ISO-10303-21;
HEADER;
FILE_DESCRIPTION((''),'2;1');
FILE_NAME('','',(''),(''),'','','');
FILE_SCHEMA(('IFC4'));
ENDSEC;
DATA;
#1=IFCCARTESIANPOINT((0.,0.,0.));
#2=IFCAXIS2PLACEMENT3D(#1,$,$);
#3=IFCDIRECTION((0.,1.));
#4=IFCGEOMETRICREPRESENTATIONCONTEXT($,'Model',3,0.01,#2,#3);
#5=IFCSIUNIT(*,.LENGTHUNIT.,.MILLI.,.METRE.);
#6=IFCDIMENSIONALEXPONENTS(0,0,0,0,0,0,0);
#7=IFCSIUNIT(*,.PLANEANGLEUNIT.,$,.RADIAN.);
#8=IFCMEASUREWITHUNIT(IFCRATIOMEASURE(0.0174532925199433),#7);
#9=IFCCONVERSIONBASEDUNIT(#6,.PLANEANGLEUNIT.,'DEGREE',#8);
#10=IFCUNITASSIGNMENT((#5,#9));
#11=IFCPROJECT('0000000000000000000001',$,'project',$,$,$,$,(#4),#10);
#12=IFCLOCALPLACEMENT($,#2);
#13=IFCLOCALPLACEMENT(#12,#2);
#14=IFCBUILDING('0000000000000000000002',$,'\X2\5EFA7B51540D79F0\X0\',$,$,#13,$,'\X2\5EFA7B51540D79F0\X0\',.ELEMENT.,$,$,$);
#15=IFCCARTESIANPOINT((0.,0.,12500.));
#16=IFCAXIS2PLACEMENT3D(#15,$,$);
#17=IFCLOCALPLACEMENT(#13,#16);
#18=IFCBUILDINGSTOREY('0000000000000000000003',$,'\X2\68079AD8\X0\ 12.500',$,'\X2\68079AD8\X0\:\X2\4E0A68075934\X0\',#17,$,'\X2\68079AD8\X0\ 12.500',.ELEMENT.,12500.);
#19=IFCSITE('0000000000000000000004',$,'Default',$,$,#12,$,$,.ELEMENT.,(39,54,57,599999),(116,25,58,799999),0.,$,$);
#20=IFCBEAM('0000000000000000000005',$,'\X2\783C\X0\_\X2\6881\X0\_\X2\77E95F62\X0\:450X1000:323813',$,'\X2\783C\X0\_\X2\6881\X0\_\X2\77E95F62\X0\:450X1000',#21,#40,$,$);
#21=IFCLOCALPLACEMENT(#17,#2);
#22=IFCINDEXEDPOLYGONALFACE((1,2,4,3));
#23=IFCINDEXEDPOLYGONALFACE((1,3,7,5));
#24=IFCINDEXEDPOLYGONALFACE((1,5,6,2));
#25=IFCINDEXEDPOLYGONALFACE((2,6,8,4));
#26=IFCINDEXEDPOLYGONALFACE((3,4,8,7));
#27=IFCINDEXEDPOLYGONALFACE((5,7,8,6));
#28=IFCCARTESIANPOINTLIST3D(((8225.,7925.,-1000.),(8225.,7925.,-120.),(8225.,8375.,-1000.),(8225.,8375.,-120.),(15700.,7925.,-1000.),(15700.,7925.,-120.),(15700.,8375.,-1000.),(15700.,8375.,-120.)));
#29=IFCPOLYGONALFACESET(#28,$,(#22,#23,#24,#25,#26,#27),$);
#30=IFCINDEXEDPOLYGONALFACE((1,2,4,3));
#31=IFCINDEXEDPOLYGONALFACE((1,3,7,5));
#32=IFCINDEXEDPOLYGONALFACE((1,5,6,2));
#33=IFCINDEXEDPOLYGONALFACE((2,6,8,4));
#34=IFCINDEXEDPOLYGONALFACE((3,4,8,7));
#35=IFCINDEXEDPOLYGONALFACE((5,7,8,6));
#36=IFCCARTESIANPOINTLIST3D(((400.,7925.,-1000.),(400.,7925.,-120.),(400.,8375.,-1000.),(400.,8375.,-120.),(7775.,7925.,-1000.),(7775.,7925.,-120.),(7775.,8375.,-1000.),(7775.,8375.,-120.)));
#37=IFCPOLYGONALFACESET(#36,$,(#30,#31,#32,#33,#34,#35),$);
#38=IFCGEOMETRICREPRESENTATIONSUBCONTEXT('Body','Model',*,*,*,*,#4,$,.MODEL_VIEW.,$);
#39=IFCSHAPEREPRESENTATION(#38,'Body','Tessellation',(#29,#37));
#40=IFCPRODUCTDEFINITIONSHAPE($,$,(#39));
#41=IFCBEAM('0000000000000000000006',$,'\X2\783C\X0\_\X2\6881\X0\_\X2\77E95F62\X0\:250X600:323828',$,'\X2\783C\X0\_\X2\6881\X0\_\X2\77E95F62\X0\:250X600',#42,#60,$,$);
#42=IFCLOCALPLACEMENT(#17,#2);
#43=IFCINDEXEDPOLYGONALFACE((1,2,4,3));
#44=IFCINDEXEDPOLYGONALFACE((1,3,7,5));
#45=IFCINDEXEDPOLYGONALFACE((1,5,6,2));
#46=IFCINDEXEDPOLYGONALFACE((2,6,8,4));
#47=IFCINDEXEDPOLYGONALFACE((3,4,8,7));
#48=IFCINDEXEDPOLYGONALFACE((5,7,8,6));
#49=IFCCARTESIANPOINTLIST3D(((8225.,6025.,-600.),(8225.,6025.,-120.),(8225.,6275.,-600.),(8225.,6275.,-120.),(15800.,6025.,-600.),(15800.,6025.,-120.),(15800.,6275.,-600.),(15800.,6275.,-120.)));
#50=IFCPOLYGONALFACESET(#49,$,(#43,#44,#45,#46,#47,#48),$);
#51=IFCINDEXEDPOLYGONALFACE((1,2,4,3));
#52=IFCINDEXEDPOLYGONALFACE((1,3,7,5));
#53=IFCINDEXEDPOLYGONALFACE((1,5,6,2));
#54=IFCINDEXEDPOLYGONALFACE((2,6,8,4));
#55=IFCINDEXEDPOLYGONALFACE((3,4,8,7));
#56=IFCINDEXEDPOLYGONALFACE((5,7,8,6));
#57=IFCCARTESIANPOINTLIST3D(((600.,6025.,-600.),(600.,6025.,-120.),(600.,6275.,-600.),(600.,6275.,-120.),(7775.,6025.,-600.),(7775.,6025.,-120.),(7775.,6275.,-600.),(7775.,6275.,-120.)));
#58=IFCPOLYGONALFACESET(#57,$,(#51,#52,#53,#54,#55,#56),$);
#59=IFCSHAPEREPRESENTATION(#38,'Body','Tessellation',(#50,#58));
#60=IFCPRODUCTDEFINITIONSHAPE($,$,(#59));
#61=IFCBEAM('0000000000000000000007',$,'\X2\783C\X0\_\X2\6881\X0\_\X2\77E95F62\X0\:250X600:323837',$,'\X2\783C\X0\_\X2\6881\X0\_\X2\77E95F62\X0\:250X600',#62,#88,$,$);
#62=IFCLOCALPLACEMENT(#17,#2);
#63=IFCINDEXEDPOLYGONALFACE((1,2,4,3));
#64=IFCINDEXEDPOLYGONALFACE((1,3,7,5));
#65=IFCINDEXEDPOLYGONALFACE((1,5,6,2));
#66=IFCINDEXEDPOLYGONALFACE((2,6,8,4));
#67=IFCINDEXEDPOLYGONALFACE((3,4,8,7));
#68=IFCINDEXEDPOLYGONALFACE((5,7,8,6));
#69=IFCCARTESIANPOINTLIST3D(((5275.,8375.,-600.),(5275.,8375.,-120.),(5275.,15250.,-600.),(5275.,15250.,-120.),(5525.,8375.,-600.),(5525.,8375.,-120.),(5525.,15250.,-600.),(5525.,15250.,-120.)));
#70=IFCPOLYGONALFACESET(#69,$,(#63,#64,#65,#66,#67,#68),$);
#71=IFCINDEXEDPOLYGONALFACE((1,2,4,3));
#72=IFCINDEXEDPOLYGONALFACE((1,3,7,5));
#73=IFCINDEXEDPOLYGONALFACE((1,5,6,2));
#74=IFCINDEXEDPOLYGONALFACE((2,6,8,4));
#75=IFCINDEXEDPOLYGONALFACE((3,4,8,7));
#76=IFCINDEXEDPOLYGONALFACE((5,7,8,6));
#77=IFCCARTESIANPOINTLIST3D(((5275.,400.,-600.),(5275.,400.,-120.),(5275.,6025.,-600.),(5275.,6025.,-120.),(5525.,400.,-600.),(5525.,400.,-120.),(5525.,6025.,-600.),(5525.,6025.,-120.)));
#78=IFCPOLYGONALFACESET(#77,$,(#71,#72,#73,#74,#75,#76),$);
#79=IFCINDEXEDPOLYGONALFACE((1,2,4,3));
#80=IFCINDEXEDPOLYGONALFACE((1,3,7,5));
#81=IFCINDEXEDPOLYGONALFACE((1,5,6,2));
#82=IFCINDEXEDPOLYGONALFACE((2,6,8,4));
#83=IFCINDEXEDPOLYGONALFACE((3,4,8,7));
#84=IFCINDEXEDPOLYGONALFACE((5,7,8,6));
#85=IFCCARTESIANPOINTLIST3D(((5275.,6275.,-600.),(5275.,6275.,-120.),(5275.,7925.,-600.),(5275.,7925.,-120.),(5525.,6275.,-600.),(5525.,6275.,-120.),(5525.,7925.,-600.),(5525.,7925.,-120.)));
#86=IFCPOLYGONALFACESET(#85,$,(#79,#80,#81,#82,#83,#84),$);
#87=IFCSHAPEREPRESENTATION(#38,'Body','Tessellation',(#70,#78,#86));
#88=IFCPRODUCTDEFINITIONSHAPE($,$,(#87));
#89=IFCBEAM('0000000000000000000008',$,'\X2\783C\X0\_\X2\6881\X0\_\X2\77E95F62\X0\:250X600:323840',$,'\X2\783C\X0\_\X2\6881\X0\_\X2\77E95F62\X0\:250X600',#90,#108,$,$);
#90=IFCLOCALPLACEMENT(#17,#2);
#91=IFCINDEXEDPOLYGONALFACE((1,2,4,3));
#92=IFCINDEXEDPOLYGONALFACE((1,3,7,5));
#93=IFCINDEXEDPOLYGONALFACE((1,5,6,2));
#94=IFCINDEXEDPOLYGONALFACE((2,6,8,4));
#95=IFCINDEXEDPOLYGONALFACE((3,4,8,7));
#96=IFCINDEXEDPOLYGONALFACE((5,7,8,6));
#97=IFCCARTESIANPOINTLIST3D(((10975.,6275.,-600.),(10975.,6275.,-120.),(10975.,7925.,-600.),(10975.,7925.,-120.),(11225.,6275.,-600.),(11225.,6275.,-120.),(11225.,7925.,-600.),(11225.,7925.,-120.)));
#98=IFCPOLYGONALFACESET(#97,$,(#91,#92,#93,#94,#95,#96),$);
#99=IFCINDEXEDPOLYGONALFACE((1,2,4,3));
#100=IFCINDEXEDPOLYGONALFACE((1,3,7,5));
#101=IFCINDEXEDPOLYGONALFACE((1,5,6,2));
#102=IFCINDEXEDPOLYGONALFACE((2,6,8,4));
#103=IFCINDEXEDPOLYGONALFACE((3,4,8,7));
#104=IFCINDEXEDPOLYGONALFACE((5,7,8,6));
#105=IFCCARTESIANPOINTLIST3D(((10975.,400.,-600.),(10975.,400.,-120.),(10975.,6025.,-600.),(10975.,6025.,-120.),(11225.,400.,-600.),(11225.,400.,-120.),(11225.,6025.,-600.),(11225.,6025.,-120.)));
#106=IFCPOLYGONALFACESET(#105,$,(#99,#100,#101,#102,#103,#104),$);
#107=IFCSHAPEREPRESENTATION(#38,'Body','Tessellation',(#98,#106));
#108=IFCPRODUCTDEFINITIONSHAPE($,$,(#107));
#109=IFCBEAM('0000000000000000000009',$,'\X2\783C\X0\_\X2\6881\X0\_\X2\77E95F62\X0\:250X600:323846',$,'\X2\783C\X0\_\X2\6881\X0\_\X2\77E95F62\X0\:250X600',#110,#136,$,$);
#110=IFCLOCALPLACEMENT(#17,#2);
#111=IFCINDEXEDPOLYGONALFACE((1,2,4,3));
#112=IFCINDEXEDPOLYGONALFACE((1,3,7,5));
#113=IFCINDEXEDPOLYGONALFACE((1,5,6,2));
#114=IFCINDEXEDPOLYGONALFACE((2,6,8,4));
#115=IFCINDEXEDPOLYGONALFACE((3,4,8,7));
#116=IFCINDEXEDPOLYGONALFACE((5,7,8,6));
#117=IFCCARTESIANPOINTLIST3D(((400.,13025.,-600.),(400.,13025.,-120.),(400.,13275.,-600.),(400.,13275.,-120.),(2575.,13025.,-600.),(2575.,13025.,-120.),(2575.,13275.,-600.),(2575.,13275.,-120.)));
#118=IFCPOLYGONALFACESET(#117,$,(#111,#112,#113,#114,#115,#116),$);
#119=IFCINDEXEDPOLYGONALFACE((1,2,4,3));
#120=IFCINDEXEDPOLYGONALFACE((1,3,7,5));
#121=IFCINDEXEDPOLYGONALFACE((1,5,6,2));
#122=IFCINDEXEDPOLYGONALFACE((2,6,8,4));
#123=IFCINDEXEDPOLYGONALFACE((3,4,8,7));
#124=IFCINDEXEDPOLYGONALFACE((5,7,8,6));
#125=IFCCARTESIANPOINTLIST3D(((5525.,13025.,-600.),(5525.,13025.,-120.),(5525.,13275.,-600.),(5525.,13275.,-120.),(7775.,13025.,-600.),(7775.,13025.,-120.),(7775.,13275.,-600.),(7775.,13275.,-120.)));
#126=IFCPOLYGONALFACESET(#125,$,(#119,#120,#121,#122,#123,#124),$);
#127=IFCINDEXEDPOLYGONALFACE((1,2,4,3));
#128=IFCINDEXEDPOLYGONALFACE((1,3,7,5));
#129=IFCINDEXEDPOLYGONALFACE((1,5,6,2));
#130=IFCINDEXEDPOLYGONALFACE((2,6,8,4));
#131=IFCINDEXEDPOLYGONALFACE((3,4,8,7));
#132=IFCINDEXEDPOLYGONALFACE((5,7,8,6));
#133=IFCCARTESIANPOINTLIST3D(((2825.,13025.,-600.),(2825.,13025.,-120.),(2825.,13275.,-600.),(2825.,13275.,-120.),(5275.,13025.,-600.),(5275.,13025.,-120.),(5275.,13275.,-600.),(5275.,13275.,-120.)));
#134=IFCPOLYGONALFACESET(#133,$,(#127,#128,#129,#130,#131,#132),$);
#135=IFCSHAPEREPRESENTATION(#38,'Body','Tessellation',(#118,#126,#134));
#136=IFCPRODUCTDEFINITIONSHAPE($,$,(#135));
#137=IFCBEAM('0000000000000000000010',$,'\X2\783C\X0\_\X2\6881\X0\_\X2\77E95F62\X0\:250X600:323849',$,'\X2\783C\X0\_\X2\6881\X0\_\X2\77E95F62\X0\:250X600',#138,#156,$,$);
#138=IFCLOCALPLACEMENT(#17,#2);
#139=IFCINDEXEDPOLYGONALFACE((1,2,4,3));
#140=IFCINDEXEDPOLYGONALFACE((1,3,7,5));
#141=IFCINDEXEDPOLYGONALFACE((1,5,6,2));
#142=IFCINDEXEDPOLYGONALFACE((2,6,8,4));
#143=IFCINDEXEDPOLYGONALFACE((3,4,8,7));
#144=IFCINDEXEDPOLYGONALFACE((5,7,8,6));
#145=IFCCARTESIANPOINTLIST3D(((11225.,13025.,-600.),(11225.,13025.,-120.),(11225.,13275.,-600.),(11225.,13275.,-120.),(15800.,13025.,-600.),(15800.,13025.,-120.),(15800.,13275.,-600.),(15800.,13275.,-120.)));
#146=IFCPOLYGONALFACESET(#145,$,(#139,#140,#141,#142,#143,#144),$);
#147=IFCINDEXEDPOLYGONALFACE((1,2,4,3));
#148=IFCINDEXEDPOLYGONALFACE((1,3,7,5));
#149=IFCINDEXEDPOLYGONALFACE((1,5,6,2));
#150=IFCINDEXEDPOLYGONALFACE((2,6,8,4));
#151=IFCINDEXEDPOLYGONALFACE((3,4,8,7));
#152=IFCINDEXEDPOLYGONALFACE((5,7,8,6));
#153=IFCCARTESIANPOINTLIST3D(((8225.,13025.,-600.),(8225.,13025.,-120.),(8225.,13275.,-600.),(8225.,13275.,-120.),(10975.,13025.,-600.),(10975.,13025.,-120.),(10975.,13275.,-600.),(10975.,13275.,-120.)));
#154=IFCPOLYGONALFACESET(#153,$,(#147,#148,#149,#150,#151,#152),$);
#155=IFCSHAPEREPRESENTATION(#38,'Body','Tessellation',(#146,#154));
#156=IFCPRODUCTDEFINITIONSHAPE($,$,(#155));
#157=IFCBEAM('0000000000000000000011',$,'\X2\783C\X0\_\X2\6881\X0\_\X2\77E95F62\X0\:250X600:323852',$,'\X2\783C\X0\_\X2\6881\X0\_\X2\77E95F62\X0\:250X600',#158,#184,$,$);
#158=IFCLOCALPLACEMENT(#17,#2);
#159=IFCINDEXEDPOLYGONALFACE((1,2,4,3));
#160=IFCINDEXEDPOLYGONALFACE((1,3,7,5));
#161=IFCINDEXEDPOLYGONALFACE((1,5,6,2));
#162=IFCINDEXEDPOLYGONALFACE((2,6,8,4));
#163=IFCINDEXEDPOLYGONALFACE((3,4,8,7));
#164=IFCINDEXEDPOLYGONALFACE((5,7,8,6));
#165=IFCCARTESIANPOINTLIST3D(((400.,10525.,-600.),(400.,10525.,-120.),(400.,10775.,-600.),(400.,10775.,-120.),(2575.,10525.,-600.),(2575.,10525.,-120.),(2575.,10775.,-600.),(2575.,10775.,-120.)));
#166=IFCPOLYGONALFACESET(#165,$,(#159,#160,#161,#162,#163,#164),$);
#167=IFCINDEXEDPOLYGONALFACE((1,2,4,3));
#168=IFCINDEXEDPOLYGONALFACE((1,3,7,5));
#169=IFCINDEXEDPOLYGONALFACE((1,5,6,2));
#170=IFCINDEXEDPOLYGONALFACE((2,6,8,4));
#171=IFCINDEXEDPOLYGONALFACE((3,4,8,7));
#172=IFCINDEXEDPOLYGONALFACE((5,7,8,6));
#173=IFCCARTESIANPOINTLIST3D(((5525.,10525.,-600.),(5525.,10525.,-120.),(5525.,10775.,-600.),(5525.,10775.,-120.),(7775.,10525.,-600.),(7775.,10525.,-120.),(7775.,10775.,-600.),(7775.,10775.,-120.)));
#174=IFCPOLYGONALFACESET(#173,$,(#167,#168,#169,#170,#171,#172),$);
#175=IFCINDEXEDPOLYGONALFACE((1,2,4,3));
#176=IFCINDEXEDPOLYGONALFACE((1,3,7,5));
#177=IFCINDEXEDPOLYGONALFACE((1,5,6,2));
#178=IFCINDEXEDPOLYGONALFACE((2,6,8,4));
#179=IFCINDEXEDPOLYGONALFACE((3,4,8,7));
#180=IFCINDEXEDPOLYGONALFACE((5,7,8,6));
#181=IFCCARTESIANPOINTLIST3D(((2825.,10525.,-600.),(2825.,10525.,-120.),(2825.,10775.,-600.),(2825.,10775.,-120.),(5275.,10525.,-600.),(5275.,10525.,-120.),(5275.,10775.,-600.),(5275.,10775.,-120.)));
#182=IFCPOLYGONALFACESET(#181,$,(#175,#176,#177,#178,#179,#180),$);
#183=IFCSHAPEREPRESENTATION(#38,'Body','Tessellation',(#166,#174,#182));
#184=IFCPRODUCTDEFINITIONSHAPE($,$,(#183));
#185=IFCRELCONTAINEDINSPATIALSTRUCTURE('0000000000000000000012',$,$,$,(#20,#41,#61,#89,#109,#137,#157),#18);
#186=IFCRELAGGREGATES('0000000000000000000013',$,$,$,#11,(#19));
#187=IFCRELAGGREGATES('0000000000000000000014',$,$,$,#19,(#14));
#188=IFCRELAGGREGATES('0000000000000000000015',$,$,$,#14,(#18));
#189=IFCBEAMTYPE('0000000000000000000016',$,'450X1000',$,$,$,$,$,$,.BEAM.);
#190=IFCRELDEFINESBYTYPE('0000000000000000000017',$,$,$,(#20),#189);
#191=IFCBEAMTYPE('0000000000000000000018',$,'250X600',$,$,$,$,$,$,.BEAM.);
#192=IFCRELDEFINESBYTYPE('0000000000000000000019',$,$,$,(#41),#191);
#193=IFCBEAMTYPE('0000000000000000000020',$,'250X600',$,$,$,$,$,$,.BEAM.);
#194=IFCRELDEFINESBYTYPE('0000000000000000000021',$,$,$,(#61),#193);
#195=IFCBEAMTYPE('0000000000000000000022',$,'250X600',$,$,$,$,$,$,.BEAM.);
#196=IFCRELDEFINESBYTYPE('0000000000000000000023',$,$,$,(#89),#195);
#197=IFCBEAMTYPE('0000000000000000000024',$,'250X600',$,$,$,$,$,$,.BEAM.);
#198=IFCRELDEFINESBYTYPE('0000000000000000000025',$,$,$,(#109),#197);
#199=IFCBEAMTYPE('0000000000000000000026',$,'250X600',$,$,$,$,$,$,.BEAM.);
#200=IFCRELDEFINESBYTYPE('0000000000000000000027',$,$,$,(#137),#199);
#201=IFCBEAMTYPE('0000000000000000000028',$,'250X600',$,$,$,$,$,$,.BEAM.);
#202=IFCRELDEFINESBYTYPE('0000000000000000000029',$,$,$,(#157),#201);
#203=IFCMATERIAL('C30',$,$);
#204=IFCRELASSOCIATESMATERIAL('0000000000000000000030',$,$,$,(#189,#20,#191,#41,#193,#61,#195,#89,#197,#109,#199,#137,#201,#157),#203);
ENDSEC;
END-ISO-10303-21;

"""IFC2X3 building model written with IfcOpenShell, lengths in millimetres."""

from ifc_helpers import new_model, entity, si_unit, converted_unit, direction, frame, frame_2d, origin, place, context, subcontext, project, spatial, rectangle, extrude, source, transform, mapped, material, type_object, type_shapes, element, save


model = new_model("IFC2X3")

# Units and contexts
model_context = context("Model", 3, precision=0.01, world=origin(), true_north=direction((0.0, 1.0)))
body_context = subcontext(model_context, "Body", "Model", "MODEL_VIEW")
ifc_project = project(units=[si_unit("LENGTHUNIT", "METRE", prefix="MILLI"), converted_unit("PLANEANGLEUNIT", "DEGREE", entity("IfcRatioMeasure", 0.0174532925199433), si_unit("PLANEANGLEUNIT", "RADIAN"), dimensions=[0, 0, 0, 0, 0, 0, 0])], contexts=[model_context])

# Site, building, storey
site_placement = place(None, origin())
site = spatial("IfcSite", under=ifc_project, at=site_placement, Name="Default", CompositionType="ELEMENT", RefLatitude=(39, 54, 57, 599999), RefLongitude=(116, 25, 58, 799999), RefElevation=0.0)
building_placement = place(site_placement, origin())
building = spatial("IfcBuilding", under=site, at=building_placement, Name="建筑名称", LongName="建筑名称", CompositionType="ELEMENT")
storey_placement = place(building_placement, frame((0.0, 0.0, 12500.0)))
storey = spatial("IfcBuildingStorey", under=building, at=storey_placement, Name="标高 12.500", ObjectType="标高:上标头", LongName="标高 12.500", CompositionType="ELEMENT", Elevation=12500.0)

# Shared definitions
ifc_material = material(Name="C30")

# Beams
beam_type_1 = type_object("IfcBeamType", Name="450X1000", PredefinedType="BEAM", material=ifc_material)
shared_shape_1 = source(origin(), body_context, "Body", "SweptSolid", [
    extrude(rectangle(XDim=880.0, YDim=450.0, at=frame_2d((0.0, 0.0), x_axis=(1.0, 0.0))), frame((8225.0, 8150.0, 11940.0), z_axis=(1.0, 0.0, 0.0), x_axis=(0.0, 0.0, -1.0)), (0.0, 0.0, 1.0), 7475.0),
    extrude(rectangle(XDim=880.0, YDim=450.0, at=frame_2d((0.0, 0.0), x_axis=(1.0, 0.0))), frame((400.0, 8150.0, 11940.0), z_axis=(1.0, 0.0, 0.0), x_axis=(0.0, 0.0, -1.0)), (0.0, 0.0, 1.0), 7375.0),
])
type_shapes(beam_type_1, [shared_shape_1])
beam_1_placement = place(storey_placement, frame((0.0, 0.0, -12500.0)))
element("IfcBeam", 1, at=beam_1_placement, inside=storey, type_object=beam_type_1, material=ifc_material, Name="砼_梁_矩形:450X1000:323813", ObjectType="砼_梁_矩形:450X1000", context=body_context, shape_type="MappedRepresentation", body=[
    mapped(shared_shape_1, transform((0.0, 0.0, 0.0), scale=1.0)),
])
beam_type_2 = type_object("IfcBeamType", Name="250X600", PredefinedType="BEAM", material=ifc_material)
shared_shape_2 = source(origin(), body_context, "Body", "SweptSolid", [
    extrude(rectangle(XDim=480.0, YDim=250.0, at=frame_2d((0.0, 0.0), x_axis=(1.0, 0.0))), frame((8225.0, 6150.0, 12140.0), z_axis=(1.0, 0.0, 0.0), x_axis=(0.0, 0.0, -1.0)), (0.0, 0.0, 1.0), 7575.0),
    extrude(rectangle(XDim=480.0, YDim=250.0, at=frame_2d((0.0, 0.0), x_axis=(1.0, 0.0))), frame((600.0, 6150.0, 12140.0), z_axis=(1.0, 0.0, 0.0), x_axis=(0.0, 0.0, -1.0)), (0.0, 0.0, 1.0), 7175.0),
])
type_shapes(beam_type_2, [shared_shape_2])
beam_2_placement = place(storey_placement, frame((0.0, 0.0, -12500.0)))
element("IfcBeam", 2, at=beam_2_placement, inside=storey, type_object=beam_type_2, material=ifc_material, Name="砼_梁_矩形:250X600:323828", ObjectType="砼_梁_矩形:250X600", context=body_context, shape_type="MappedRepresentation", body=[
    mapped(shared_shape_2, transform((0.0, 0.0, 0.0), scale=1.0)),
])
beam_type_3 = type_object("IfcBeamType", Name="250X600", PredefinedType="BEAM", material=ifc_material)
shared_shape_3 = source(origin(), body_context, "Body", "SweptSolid", [
    extrude(rectangle(XDim=480.0, YDim=250.0, at=frame_2d((0.0, 0.0), x_axis=(0.0, 1.0))), frame((5400.0, 8375.0, 12140.0), z_axis=(0.0, 1.0, 0.0), x_axis=(-1.0, 0.0, 0.0)), (0.0, 0.0, 1.0), 6875.0),
    extrude(rectangle(XDim=480.0, YDim=250.0, at=frame_2d((0.0, 0.0), x_axis=(0.0, 1.0))), frame((5400.0, 400.0, 12140.0), z_axis=(0.0, 1.0, 0.0), x_axis=(-1.0, 0.0, 0.0)), (0.0, 0.0, 1.0), 5625.0),
    extrude(rectangle(XDim=480.0, YDim=250.0, at=frame_2d((0.0, 0.0), x_axis=(0.0, 1.0))), frame((5400.0, 6275.0, 12140.0), z_axis=(0.0, 1.0, 0.0), x_axis=(-1.0, 0.0, 0.0)), (0.0, 0.0, 1.0), 1650.0),
])
type_shapes(beam_type_3, [shared_shape_3])
beam_3_placement = place(storey_placement, frame((0.0, 0.0, -12500.0)))
element("IfcBeam", 3, at=beam_3_placement, inside=storey, type_object=beam_type_3, material=ifc_material, Name="砼_梁_矩形:250X600:323837", ObjectType="砼_梁_矩形:250X600", context=body_context, shape_type="MappedRepresentation", body=[
    mapped(shared_shape_3, transform((0.0, 0.0, 0.0), scale=1.0)),
])
beam_type_4 = type_object("IfcBeamType", Name="250X600", PredefinedType="BEAM", material=ifc_material)
shared_shape_4 = source(origin(), body_context, "Body", "SweptSolid", [
    extrude(rectangle(XDim=480.0, YDim=250.0, at=frame_2d((0.0, 0.0), x_axis=(0.0, 1.0))), frame((11100.0, 6275.0, 12140.0), z_axis=(0.0, 1.0, 0.0), x_axis=(-1.0, 0.0, 0.0)), (0.0, 0.0, 1.0), 1650.0),
    extrude(rectangle(XDim=480.0, YDim=250.0, at=frame_2d((0.0, 0.0), x_axis=(0.0, 1.0))), frame((11100.0, 400.0, 12140.0), z_axis=(0.0, 1.0, 0.0), x_axis=(-1.0, 0.0, 0.0)), (0.0, 0.0, 1.0), 5625.0),
])
type_shapes(beam_type_4, [shared_shape_4])
beam_4_placement = place(storey_placement, frame((0.0, 0.0, -12500.0)))
element("IfcBeam", 4, at=beam_4_placement, inside=storey, type_object=beam_type_4, material=ifc_material, Name="砼_梁_矩形:250X600:323840", ObjectType="砼_梁_矩形:250X600", context=body_context, shape_type="MappedRepresentation", body=[
    mapped(shared_shape_4, transform((0.0, 0.0, 0.0), scale=1.0)),
])
beam_type_5 = type_object("IfcBeamType", Name="250X600", PredefinedType="BEAM", material=ifc_material)
shared_shape_5 = source(origin(), body_context, "Body", "SweptSolid", [
    extrude(rectangle(XDim=480.0, YDim=250.0, at=frame_2d((0.0, 0.0), x_axis=(1.0, 0.0))), frame((400.0, 13150.0, 12140.0), z_axis=(1.0, 0.0, 0.0), x_axis=(0.0, 0.0, -1.0)), (0.0, 0.0, 1.0), 2175.0),
    extrude(rectangle(XDim=480.0, YDim=250.0, at=frame_2d((0.0, 0.0), x_axis=(1.0, 0.0))), frame((5525.0, 13150.0, 12140.0), z_axis=(1.0, 0.0, 0.0), x_axis=(0.0, 0.0, -1.0)), (0.0, 0.0, 1.0), 2250.0),
    extrude(rectangle(XDim=480.0, YDim=250.0, at=frame_2d((0.0, 0.0), x_axis=(1.0, 0.0))), frame((2825.0, 13150.0, 12140.0), z_axis=(1.0, 0.0, 0.0), x_axis=(0.0, 0.0, -1.0)), (0.0, 0.0, 1.0), 2450.0),
])
type_shapes(beam_type_5, [shared_shape_5])
beam_5_placement = place(storey_placement, frame((0.0, 0.0, -12500.0)))
element("IfcBeam", 5, at=beam_5_placement, inside=storey, type_object=beam_type_5, material=ifc_material, Name="砼_梁_矩形:250X600:323846", ObjectType="砼_梁_矩形:250X600", context=body_context, shape_type="MappedRepresentation", body=[
    mapped(shared_shape_5, transform((0.0, 0.0, 0.0), scale=1.0)),
])
beam_type_6 = type_object("IfcBeamType", Name="250X600", PredefinedType="BEAM", material=ifc_material)
shared_shape_6 = source(origin(), body_context, "Body", "SweptSolid", [
    extrude(rectangle(XDim=480.0, YDim=250.0, at=frame_2d((0.0, 0.0), x_axis=(1.0, 0.0))), frame((11225.0, 13150.0, 12140.0), z_axis=(1.0, 0.0, 0.0), x_axis=(0.0, 0.0, -1.0)), (0.0, 0.0, 1.0), 4575.0),
    extrude(rectangle(XDim=480.0, YDim=250.0, at=frame_2d((0.0, 0.0), x_axis=(1.0, 0.0))), frame((8225.0, 13150.0, 12140.0), z_axis=(1.0, 0.0, 0.0), x_axis=(0.0, 0.0, -1.0)), (0.0, 0.0, 1.0), 2750.0),
])
type_shapes(beam_type_6, [shared_shape_6])
beam_6_placement = place(storey_placement, frame((0.0, 0.0, -12500.0)))
element("IfcBeam", 6, at=beam_6_placement, inside=storey, type_object=beam_type_6, material=ifc_material, Name="砼_梁_矩形:250X600:323849", ObjectType="砼_梁_矩形:250X600", context=body_context, shape_type="MappedRepresentation", body=[
    mapped(shared_shape_6, transform((0.0, 0.0, 0.0), scale=1.0)),
])
beam_type_7 = type_object("IfcBeamType", Name="250X600", PredefinedType="BEAM", material=ifc_material)
shared_shape_7 = source(origin(), body_context, "Body", "SweptSolid", [
    extrude(rectangle(XDim=480.0, YDim=250.0, at=frame_2d((0.0, 0.0), x_axis=(1.0, 0.0))), frame((400.0, 10650.0, 12140.0), z_axis=(1.0, 0.0, 0.0), x_axis=(0.0, 0.0, -1.0)), (0.0, 0.0, 1.0), 2175.0),
    extrude(rectangle(XDim=480.0, YDim=250.0, at=frame_2d((0.0, 0.0), x_axis=(1.0, 0.0))), frame((5525.0, 10650.0, 12140.0), z_axis=(1.0, 0.0, 0.0), x_axis=(0.0, 0.0, -1.0)), (0.0, 0.0, 1.0), 2250.0),
    extrude(rectangle(XDim=480.0, YDim=250.0, at=frame_2d((0.0, 0.0), x_axis=(1.0, 0.0))), frame((2825.0, 10650.0, 12140.0), z_axis=(1.0, 0.0, 0.0), x_axis=(0.0, 0.0, -1.0)), (0.0, 0.0, 1.0), 2450.0),
])
type_shapes(beam_type_7, [shared_shape_7])
beam_7_placement = place(storey_placement, frame((0.0, 0.0, -12500.0)))
element("IfcBeam", 7, at=beam_7_placement, inside=storey, type_object=beam_type_7, material=ifc_material, Name="砼_梁_矩形:250X600:323852", ObjectType="砼_梁_矩形:250X600", context=body_context, shape_type="MappedRepresentation", body=[
    mapped(shared_shape_7, transform((0.0, 0.0, 0.0), scale=1.0)),
])

save(model, "model.ifc")
